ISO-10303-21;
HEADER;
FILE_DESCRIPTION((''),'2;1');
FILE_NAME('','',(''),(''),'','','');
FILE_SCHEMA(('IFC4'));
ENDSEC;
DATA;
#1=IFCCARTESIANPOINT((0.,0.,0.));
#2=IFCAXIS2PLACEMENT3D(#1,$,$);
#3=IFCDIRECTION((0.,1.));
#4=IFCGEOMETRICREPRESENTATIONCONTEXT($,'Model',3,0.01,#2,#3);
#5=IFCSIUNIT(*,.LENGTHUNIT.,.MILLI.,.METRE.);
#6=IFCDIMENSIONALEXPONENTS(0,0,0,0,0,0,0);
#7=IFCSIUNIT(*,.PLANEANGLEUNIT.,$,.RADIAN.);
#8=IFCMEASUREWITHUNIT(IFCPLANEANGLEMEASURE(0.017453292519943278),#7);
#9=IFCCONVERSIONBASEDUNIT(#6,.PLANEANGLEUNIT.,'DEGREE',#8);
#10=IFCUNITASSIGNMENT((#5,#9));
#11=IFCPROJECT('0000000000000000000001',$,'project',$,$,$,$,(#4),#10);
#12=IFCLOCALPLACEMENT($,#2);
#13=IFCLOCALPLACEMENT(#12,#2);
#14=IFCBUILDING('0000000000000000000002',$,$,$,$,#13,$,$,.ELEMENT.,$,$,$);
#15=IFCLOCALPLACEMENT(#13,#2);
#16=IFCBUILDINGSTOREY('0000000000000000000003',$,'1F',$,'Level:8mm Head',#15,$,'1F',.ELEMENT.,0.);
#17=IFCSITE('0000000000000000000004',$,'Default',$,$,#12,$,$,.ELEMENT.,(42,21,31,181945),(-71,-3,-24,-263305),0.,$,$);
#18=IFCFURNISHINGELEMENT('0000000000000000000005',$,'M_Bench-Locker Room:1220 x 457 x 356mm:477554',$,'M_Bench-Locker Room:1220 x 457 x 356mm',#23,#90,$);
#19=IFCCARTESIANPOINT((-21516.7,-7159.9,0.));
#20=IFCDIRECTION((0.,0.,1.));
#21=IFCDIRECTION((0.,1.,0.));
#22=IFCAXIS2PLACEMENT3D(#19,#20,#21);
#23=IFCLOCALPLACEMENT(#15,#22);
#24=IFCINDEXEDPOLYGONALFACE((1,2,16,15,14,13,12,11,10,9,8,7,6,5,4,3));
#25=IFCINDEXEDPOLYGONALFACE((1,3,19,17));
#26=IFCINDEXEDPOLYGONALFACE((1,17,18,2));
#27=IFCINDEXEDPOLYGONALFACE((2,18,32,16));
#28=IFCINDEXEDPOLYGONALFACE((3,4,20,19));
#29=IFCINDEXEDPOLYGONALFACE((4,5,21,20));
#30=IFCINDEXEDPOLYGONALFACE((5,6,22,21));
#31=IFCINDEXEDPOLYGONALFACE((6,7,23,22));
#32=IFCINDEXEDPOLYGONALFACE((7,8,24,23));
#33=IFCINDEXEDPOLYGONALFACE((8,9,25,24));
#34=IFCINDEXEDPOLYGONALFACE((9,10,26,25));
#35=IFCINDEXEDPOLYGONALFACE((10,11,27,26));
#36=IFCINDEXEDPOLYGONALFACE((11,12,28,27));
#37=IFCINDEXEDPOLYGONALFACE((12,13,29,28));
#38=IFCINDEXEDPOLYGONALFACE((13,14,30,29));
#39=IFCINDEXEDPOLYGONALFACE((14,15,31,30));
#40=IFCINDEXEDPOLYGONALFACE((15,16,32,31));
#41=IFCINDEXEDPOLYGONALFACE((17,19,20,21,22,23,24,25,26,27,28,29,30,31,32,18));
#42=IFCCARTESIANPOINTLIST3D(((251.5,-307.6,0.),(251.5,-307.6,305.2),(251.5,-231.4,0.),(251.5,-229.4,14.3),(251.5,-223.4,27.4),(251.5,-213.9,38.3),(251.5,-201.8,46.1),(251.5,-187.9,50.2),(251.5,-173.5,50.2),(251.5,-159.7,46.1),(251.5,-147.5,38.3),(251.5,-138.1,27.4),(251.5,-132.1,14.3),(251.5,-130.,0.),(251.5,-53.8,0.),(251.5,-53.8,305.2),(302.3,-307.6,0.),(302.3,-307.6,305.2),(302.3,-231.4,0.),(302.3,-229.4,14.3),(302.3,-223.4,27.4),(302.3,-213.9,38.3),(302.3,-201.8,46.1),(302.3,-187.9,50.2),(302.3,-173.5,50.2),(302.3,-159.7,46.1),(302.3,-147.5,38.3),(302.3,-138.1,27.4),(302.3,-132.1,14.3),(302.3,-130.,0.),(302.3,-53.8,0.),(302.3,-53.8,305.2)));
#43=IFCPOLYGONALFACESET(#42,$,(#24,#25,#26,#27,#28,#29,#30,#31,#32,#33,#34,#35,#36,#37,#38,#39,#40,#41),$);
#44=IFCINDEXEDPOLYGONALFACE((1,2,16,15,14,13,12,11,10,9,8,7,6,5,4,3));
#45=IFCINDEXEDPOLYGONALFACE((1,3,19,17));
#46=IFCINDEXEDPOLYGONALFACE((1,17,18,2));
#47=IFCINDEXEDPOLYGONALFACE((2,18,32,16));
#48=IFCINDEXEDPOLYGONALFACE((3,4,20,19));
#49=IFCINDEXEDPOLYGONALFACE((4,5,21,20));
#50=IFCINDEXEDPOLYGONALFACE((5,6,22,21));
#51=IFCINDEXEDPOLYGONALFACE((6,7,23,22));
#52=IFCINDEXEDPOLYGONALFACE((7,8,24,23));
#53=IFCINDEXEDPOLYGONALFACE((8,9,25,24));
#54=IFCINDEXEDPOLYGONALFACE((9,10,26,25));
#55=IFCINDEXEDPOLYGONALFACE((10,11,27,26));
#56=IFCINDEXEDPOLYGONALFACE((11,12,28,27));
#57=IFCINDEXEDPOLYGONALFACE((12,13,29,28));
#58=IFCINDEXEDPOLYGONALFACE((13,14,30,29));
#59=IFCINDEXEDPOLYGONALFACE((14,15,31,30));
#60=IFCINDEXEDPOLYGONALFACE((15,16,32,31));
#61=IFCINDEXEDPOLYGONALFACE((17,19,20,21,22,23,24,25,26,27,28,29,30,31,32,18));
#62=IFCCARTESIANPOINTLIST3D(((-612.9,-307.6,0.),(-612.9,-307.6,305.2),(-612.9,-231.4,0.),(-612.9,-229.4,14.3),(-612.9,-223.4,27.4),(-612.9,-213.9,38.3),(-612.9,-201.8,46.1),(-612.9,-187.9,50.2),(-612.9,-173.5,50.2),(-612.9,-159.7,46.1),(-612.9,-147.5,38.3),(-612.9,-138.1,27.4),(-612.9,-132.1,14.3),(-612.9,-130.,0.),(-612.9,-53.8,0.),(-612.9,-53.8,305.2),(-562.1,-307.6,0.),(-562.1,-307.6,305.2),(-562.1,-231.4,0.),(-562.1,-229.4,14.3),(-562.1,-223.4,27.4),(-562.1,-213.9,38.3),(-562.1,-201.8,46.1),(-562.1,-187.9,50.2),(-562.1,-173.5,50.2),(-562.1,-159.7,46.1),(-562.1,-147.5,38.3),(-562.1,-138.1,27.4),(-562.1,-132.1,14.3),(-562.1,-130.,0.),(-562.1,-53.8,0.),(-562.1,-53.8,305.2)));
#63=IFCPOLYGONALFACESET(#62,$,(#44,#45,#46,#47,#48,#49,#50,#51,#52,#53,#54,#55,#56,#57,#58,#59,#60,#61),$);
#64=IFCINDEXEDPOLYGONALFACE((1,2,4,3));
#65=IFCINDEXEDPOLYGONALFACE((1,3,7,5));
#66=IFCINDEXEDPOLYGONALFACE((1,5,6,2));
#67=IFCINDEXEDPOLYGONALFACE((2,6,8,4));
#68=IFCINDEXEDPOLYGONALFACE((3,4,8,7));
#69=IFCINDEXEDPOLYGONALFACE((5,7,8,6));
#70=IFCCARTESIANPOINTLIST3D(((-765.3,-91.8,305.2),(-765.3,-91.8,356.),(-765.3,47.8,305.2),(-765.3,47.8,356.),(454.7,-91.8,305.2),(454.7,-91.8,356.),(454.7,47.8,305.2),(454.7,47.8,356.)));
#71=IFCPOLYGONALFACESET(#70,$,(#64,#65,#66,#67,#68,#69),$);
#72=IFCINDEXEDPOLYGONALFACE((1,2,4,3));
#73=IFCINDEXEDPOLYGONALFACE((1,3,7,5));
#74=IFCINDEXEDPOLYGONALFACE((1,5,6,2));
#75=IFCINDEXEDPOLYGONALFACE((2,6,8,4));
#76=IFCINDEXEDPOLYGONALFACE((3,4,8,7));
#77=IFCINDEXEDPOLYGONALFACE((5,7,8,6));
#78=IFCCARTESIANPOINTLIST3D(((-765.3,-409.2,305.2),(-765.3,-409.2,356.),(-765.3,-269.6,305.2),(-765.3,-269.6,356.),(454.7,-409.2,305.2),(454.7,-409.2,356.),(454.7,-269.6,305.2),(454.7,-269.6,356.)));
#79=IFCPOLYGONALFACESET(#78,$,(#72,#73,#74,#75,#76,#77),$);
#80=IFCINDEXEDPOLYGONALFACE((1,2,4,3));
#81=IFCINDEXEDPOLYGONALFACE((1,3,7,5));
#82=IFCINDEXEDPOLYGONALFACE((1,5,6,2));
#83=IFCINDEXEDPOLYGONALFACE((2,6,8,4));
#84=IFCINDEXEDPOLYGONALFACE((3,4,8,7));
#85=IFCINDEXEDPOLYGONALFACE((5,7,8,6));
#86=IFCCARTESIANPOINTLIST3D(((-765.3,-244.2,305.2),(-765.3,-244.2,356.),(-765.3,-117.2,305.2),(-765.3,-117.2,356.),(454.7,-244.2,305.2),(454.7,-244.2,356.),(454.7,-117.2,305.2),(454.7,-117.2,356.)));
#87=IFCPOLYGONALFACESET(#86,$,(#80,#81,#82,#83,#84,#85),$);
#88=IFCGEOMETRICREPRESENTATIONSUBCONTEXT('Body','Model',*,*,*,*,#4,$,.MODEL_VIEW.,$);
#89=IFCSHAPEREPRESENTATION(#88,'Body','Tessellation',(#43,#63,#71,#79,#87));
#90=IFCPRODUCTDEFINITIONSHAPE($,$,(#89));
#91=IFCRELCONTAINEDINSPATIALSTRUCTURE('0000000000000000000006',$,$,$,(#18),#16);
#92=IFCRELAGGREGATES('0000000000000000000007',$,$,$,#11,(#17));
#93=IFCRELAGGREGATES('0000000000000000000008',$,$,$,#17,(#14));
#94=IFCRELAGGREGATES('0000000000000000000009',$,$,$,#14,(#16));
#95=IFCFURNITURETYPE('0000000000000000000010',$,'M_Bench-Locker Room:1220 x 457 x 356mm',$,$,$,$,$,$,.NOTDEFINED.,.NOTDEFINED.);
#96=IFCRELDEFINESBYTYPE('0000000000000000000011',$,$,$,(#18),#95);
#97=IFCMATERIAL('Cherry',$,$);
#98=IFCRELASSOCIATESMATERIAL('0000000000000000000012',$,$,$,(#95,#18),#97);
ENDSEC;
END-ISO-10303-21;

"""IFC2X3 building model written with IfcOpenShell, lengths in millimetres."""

from ifc_helpers import new_model, entity, si_unit, converted_unit, direction, frame, frame_2d, origin, origin_2d_with_axis, place, context, subcontext, project, spatial, polyline, circle_curve, parameter, trimmed, segment, composite_curve, rectangle, outline, extrude, source, transform, mapped, material, type_object, type_shapes, element, save


model = new_model("IFC2X3")

# Units and contexts
model_context = context("Model", 3, precision=0.01, world=origin(), true_north=direction((0.0, 1.0)))
body_context = subcontext(model_context, "Body", "Model", "MODEL_VIEW")
ifc_project = project(units=[si_unit("LENGTHUNIT", "METRE", prefix="MILLI"), converted_unit("PLANEANGLEUNIT", "DEGREE", entity("IfcPlaneAngleMeasure", 0.017453292519943278), si_unit("PLANEANGLEUNIT", "RADIAN"), dimensions=[0, 0, 0, 0, 0, 0, 0])], contexts=[model_context])

# Site, building, storey
site_placement = place(None, origin())
site = spatial("IfcSite", under=ifc_project, at=site_placement, Name="Default", CompositionType="ELEMENT", RefLatitude=(42, 21, 31, 181945), RefLongitude=(-71, -3, -24, -263305), RefElevation=0.0)
building_placement = place(site_placement, origin())
building = spatial("IfcBuilding", under=site, at=building_placement, CompositionType="ELEMENT")
storey_placement = place(building_placement, origin())
storey = spatial("IfcBuildingStorey", under=building, at=storey_placement, Name="1F", ObjectType="Level:8mm Head", LongName="1F", CompositionType="ELEMENT", Elevation=0.0)

# Furnishing element
ifc_material_1 = material(Name="Cherry")
furniture_type_1 = type_object("IfcFurnitureType", Name="M_Bench-Locker Room:1220 x 457 x 356mm", AssemblyPlace="NOTDEFINED", material=ifc_material_1)
shared_shape_1 = source(origin(), body_context, "Body", "SweptSolid", [
    extrude(outline(composite_curve([segment(polyline([(-126.9, 101.7), (-126.9, -203.5)]), True, "CONTINUOUS"), segment(polyline([(-126.9, -203.5), (126.9, -203.5)]), True, "CONTINUOUS"), segment(polyline([(126.9, -203.5), (126.9, 101.7)]), True, "CONTINUOUS"), segment(polyline([(126.9, 101.7), (50.7, 101.7)]), True, "CONTINUOUS"), segment(trimmed(circle_curve(frame_2d((0.0, 101.7), x_axis=(0.0, 1.0)), 50.7), [parameter(90.0)], [parameter(270.0)], True, "PARAMETER"), False, "CONTINUOUS"), segment(polyline([(-50.7, 101.7), (-126.9, 101.7)]), True, "CONTINUOUS")], self_intersect=False)), frame((251.5, -180.7, 101.7), z_axis=(-1.0, 0.0, 0.0), x_axis=(0.0, 1.0, 0.0)), (0.0, 0.0, -1.0), 50.8),
    extrude(outline(composite_curve([segment(polyline([(-101.7, -126.9), (203.5, -126.9)]), True, "CONTINUOUS"), segment(polyline([(203.5, -126.9), (203.5, 126.9)]), True, "CONTINUOUS"), segment(polyline([(203.5, 126.9), (-101.7, 126.9)]), True, "CONTINUOUS"), segment(polyline([(-101.7, 126.9), (-101.7, 50.7)]), True, "CONTINUOUS"), segment(trimmed(circle_curve(frame_2d((-101.7, 0.0), x_axis=(-1.0, 0.0)), 50.7), [parameter(90.0)], [parameter(270.0)], True, "PARAMETER"), False, "CONTINUOUS"), segment(polyline([(-101.7, -50.7), (-101.7, -126.9)]), True, "CONTINUOUS")], self_intersect=False)), frame((-612.9, -180.7, 101.7), z_axis=(1.0, 0.0, 0.0), x_axis=(0.0, 0.0, 1.0)), (0.0, 0.0, 1.0), 50.8),
    extrude(rectangle(XDim=1220.0, YDim=139.6, at=origin_2d_with_axis()), frame((-155.3, -22.0, 305.2), z_axis=(0.0, 0.0, 1.0), x_axis=(-1.0, 0.0, 0.0)), (0.0, 0.0, 1.0), 50.8),
    extrude(rectangle(XDim=139.6, YDim=1220.0, at=frame_2d((0.0, 0.0), x_axis=(1.0, 0.0))), frame((-155.3, -339.4, 305.2), z_axis=(0.0, 0.0, 1.0), x_axis=(0.0, 1.0, 0.0)), (0.0, 0.0, 1.0), 50.8),
    extrude(rectangle(XDim=1220.0, YDim=126.9, at=frame_2d((0.0, 0.0), x_axis=(1.0, 0.0))), frame((-155.3, -180.7, 305.2), z_axis=(0.0, 0.0, 1.0), x_axis=(-1.0, 0.0, 0.0)), (0.0, 0.0, 1.0), 50.8),
])
type_shapes(furniture_type_1, [shared_shape_1])
furnishing_placement = place(storey_placement, frame((-21516.7, -7159.9, 0.0), z_axis=(0.0, 0.0, 1.0), x_axis=(0.0, 1.0, 0.0)))
element("IfcFurnishingElement", 1, at=furnishing_placement, inside=storey, type_object=furniture_type_1, material=ifc_material_1, Name="M_Bench-Locker Room:1220 x 457 x 356mm:477554", ObjectType="M_Bench-Locker Room:1220 x 457 x 356mm", context=body_context, shape_type="MappedRepresentation", body=[
    mapped(shared_shape_1, transform((0.0, 0.0, 0.0), scale=1.0)),
])

save(model, "model.ifc")
